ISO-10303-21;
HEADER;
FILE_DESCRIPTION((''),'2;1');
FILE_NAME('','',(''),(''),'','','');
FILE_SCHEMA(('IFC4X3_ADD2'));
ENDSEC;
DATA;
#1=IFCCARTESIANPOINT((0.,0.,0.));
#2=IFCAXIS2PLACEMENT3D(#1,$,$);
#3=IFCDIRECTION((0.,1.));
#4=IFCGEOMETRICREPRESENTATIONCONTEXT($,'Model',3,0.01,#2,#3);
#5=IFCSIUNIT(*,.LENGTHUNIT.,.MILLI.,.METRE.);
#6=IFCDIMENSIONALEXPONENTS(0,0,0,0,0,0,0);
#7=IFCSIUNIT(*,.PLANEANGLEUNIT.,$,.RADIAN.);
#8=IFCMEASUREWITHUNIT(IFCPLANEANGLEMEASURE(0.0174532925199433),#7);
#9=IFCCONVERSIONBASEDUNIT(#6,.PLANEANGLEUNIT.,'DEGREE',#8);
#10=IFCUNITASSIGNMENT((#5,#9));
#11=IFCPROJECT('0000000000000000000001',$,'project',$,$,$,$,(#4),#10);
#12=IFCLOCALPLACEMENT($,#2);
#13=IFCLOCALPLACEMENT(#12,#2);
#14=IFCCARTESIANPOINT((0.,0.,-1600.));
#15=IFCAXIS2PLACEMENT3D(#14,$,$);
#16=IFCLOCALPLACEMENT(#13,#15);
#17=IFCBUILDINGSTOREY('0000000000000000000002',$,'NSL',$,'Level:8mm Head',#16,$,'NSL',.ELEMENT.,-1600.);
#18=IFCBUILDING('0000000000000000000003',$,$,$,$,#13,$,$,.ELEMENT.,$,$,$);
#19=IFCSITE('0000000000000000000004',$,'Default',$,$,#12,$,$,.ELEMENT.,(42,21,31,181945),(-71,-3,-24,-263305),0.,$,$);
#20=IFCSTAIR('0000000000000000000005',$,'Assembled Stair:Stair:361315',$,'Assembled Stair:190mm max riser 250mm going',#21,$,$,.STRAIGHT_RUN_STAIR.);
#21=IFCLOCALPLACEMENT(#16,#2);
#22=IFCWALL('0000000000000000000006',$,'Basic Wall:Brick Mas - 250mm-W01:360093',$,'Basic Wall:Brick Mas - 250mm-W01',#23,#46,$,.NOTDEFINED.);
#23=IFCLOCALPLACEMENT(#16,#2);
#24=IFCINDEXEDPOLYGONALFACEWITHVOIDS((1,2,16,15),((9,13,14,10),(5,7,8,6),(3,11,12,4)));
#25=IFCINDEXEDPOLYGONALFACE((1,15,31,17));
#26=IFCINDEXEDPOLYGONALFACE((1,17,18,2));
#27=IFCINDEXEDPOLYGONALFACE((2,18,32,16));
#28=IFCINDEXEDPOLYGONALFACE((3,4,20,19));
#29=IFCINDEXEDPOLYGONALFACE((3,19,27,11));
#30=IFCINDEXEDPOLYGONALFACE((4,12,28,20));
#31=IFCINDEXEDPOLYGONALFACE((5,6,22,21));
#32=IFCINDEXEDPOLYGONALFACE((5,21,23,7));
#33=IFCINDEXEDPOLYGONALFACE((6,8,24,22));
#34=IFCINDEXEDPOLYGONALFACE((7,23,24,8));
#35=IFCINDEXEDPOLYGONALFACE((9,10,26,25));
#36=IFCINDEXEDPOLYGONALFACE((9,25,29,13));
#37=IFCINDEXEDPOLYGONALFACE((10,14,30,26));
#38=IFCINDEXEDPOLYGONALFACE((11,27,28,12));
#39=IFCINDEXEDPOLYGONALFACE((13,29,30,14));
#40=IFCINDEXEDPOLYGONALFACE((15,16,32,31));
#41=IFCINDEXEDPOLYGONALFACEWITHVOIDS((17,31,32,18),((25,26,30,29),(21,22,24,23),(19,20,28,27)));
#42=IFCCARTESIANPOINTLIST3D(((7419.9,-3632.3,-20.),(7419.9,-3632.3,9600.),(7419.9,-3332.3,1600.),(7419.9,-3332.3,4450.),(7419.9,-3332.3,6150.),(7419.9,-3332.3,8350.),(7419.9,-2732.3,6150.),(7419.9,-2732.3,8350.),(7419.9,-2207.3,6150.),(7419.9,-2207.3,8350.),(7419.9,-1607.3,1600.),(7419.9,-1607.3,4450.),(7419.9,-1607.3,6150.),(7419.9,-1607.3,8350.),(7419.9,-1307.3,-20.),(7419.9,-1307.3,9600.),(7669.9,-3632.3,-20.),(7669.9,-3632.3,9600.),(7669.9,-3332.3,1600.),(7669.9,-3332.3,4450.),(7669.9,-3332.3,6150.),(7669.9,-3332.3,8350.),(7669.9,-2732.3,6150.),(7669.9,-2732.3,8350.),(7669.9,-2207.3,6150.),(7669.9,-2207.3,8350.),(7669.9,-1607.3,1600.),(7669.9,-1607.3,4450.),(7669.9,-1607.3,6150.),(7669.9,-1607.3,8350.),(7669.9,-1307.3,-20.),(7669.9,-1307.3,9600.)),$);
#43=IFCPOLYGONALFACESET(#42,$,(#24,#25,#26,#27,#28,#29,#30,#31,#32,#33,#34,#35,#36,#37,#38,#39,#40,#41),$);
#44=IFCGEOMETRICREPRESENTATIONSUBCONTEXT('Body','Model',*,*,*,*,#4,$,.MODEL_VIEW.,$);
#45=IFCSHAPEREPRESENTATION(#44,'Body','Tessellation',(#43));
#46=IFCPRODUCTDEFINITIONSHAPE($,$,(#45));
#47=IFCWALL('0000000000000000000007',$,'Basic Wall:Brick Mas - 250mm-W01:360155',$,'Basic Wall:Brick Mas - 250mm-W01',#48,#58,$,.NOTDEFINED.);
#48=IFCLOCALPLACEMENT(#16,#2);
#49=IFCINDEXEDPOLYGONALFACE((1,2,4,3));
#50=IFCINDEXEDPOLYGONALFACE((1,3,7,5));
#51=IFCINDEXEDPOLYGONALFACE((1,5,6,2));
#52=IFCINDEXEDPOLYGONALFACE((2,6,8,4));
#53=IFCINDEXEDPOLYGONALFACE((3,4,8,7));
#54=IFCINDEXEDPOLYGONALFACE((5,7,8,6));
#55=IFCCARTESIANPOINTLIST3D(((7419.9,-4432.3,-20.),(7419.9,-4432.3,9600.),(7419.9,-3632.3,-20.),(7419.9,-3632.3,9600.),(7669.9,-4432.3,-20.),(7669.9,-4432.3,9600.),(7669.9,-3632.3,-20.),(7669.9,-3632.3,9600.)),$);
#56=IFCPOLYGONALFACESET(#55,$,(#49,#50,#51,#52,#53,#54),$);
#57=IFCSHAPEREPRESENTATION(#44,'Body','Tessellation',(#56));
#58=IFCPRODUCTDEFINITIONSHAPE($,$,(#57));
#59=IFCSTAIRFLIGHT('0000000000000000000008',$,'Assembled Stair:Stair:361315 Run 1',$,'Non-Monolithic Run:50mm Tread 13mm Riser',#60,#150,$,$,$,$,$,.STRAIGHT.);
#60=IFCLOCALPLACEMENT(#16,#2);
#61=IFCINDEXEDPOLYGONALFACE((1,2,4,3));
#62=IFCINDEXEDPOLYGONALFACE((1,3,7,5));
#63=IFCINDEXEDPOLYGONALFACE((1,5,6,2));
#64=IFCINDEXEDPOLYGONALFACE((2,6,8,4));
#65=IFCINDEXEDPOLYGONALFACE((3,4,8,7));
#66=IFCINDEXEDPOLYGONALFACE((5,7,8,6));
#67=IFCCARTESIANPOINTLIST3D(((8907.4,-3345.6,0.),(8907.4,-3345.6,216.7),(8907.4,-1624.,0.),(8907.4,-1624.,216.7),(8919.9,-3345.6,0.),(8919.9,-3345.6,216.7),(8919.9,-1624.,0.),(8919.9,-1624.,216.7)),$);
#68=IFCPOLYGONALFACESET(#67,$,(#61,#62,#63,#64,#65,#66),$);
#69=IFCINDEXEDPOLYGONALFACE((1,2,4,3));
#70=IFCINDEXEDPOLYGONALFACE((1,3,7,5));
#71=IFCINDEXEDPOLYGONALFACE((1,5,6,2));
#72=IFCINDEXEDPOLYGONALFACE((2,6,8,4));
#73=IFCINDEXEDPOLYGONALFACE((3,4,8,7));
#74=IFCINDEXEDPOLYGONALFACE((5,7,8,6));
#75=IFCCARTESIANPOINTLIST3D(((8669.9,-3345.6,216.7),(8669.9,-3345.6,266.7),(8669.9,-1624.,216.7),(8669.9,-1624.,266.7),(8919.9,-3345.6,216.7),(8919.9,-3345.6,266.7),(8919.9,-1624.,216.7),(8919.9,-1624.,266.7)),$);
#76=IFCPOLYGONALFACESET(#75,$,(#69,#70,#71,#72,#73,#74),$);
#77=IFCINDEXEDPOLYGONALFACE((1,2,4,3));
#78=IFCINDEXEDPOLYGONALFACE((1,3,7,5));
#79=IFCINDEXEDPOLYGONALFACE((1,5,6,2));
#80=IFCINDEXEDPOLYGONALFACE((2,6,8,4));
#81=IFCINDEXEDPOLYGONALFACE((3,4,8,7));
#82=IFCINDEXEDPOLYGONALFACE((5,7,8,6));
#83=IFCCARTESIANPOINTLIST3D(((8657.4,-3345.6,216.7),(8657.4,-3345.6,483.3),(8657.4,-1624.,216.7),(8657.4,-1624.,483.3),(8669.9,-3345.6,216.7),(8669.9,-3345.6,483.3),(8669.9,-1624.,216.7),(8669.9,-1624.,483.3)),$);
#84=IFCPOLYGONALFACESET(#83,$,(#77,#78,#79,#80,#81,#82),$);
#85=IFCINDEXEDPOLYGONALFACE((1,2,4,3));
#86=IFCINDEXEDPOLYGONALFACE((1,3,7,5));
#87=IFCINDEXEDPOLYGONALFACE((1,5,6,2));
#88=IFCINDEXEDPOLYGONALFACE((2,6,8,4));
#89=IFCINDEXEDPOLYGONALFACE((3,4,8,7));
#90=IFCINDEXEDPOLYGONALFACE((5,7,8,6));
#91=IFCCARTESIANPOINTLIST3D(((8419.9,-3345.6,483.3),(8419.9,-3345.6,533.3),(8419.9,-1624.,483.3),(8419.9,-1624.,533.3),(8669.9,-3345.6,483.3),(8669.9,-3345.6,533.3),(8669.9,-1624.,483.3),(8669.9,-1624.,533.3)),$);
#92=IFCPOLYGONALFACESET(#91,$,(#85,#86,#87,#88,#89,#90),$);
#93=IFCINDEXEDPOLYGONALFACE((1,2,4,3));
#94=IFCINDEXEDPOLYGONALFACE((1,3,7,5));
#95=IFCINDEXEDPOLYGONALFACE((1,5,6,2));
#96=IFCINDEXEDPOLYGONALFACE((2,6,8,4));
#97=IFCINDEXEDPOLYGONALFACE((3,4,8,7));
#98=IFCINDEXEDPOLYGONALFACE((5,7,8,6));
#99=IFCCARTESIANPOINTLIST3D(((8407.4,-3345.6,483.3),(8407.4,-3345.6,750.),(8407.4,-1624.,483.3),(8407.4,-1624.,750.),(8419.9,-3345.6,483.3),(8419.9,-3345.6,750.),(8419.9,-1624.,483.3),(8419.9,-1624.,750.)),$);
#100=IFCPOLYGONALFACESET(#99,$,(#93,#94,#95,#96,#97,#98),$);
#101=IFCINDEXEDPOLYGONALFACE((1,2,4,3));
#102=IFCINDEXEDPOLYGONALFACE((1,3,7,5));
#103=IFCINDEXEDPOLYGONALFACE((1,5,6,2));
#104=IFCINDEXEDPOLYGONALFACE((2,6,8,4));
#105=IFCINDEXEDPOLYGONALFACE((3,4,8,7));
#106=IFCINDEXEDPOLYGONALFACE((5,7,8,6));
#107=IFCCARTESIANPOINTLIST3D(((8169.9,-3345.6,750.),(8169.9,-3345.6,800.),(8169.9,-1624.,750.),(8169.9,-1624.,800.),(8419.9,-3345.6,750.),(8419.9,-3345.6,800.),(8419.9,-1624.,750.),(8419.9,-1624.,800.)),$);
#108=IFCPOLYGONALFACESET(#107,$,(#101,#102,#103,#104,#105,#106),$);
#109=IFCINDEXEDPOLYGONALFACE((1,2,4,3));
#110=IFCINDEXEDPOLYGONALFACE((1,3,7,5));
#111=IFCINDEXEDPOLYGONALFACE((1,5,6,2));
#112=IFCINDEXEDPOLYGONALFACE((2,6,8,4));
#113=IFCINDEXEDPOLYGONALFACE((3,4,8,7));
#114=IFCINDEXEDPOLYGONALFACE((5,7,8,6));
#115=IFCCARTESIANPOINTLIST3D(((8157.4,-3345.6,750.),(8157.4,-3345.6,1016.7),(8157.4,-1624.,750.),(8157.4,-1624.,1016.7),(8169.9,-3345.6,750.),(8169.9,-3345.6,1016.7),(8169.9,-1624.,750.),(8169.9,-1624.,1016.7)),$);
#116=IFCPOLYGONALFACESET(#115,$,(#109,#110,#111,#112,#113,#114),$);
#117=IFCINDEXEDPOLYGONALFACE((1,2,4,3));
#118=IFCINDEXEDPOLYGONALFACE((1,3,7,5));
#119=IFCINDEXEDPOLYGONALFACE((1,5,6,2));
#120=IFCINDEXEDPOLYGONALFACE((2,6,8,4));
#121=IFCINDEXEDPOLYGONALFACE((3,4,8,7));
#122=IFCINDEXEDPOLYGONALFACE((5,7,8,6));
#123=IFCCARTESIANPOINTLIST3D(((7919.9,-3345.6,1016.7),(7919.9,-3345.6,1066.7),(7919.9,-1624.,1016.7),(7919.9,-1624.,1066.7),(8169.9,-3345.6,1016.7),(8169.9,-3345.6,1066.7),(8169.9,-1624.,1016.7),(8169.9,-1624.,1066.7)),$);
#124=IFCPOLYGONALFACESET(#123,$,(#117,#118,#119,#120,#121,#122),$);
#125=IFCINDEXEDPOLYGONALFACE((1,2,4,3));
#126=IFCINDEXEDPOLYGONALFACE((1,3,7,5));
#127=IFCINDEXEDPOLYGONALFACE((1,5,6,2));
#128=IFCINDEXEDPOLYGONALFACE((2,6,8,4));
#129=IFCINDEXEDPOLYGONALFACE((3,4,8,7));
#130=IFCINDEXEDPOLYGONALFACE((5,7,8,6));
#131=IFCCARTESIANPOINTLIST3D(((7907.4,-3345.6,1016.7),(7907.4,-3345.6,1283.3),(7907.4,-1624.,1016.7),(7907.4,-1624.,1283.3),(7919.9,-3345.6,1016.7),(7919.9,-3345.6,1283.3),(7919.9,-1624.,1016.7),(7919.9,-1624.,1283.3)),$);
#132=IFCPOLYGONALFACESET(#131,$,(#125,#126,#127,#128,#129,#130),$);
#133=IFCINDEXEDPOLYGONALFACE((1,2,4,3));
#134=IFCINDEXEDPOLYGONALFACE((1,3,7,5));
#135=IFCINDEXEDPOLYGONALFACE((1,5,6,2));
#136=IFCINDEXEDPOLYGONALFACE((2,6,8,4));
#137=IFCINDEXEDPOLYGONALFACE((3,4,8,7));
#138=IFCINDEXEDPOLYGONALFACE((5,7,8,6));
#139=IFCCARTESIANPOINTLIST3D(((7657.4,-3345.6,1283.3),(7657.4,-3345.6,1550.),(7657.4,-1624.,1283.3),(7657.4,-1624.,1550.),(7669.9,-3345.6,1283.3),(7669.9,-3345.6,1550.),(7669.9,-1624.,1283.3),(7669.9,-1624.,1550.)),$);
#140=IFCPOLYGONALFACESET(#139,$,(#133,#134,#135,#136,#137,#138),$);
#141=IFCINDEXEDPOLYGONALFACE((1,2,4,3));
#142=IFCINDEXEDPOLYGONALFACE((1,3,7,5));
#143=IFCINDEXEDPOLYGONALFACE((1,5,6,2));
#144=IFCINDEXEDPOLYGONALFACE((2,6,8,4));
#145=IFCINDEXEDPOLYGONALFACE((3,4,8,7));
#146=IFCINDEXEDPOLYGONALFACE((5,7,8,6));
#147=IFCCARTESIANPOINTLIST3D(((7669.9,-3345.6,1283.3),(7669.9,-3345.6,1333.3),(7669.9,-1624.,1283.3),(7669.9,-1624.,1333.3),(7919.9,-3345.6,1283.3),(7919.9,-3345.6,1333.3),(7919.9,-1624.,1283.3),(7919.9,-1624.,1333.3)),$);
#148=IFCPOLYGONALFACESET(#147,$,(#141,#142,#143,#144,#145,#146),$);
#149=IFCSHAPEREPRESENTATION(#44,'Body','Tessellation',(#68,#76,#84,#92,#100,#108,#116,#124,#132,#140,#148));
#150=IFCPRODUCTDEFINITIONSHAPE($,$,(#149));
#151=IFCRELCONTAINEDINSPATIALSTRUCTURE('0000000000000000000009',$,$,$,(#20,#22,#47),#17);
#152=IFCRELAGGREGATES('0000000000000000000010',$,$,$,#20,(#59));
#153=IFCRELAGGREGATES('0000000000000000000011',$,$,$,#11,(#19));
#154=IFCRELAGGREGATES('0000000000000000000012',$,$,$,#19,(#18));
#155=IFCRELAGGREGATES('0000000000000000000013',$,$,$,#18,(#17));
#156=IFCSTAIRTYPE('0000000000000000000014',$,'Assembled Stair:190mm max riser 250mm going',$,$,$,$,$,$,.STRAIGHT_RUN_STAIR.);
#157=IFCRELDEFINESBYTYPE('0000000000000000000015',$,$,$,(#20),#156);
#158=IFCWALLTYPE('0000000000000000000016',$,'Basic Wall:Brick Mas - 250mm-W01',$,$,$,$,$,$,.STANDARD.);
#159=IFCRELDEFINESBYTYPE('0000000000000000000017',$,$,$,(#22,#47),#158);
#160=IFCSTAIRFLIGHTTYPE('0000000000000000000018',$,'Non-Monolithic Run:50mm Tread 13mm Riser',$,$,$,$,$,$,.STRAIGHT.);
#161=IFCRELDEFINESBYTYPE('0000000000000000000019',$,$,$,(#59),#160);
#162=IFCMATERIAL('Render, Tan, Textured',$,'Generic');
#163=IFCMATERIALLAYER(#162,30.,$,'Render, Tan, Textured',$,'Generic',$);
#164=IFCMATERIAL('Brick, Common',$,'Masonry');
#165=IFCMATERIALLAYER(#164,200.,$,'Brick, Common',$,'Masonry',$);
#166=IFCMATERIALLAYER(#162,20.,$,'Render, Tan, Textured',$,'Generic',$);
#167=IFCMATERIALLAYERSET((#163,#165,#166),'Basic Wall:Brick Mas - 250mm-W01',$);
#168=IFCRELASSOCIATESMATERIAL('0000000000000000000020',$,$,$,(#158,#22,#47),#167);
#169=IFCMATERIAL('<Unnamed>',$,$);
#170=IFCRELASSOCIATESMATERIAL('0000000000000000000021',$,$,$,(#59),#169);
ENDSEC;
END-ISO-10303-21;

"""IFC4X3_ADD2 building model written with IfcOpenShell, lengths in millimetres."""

from ifc_helpers import new_model, entity, si_unit, converted_unit, direction, frame, frame_2d, origin, origin_2d_with_axis, place, context, subcontext, project, spatial, rectangle, extrude, material, layer, layer_set, type_object, element, aggregate, save


model = new_model("IFC4X3_ADD2")

# Units and contexts
model_context = context("Model", 3, precision=0.01, world=origin(), true_north=direction((0.0, 1.0)))
body_context = subcontext(model_context, "Body", "Model", "MODEL_VIEW")
ifc_project = project(units=[si_unit("LENGTHUNIT", "METRE", prefix="MILLI"), converted_unit("PLANEANGLEUNIT", "DEGREE", entity("IfcPlaneAngleMeasure", 0.0174532925199433), si_unit("PLANEANGLEUNIT", "RADIAN"), dimensions=[0, 0, 0, 0, 0, 0, 0])], contexts=[model_context])

# Site, building, storey
site_placement = place(None, origin())
site = spatial("IfcSite", under=ifc_project, at=site_placement, Name="Default", CompositionType="ELEMENT", RefLatitude=(42, 21, 31, 181945), RefLongitude=(-71, -3, -24, -263305), RefElevation=0.0)
building_placement = place(site_placement, origin())
building = spatial("IfcBuilding", under=site, at=building_placement, CompositionType="ELEMENT")
storey_placement = place(building_placement, frame((0.0, 0.0, -1600.0)))
storey = spatial("IfcBuildingStorey", under=building, at=storey_placement, Name="NSL", ObjectType="Level:8mm Head", LongName="NSL", CompositionType="ELEMENT", Elevation=-1600.0)

# Stair
stair_type = type_object("IfcStairType", Name="Assembled Stair:190mm max riser 250mm going", PredefinedType="STRAIGHT_RUN_STAIR")
stair_placement = place(storey_placement, origin())
stair = element("IfcStair", 1, at=stair_placement, inside=storey, type_object=stair_type, Name="Assembled Stair:Stair:361315", ObjectType="Assembled Stair:190mm max riser 250mm going", PredefinedType="STRAIGHT_RUN_STAIR")
ifc_material_1 = material(Name="<Unnamed>")

# Shared definitions
ifc_material_2 = material(Name="Render, Tan, Textured", Category="Generic")
ifc_layer_1 = layer(ifc_material_2, 30.0, Name="Render, Tan, Textured", Category="Generic")
ifc_material_3 = material(Name="Brick, Common", Category="Masonry")
ifc_layer_2 = layer(ifc_material_3, 200.0, Name="Brick, Common", Category="Masonry")
ifc_layer_3 = layer(ifc_material_2, 20.0, Name="Render, Tan, Textured", Category="Generic")
ifc_layer_set = layer_set([ifc_layer_1, ifc_layer_2, ifc_layer_3], Name="Basic Wall:Brick Mas - 250mm-W01")
wall_type = type_object("IfcWallType", Name="Basic Wall:Brick Mas - 250mm-W01", PredefinedType="STANDARD", material=ifc_layer_set)

# Wall, openings
wall_1_placement = place(storey_placement, frame((7544.9, -1307.3, -20.0), z_axis=(0.0, 0.0, 1.0), x_axis=(0.0, -1.0, 0.0)))
wall_1 = element("IfcWall", 2, at=wall_1_placement, inside=storey, type_object=wall_type, material=ifc_layer_set, Name="Basic Wall:Brick Mas - 250mm-W01:360093", ObjectType="Basic Wall:Brick Mas - 250mm-W01", PredefinedType="NOTDEFINED", context=body_context, shape_type="SweptSolid", body=[
    extrude(rectangle(XDim=2325.0, YDim=250.0, at=frame_2d((1162.5, 0.0), x_axis=(-1.0, 0.0))), origin(), (0.0, 0.0, 1.0), 9620.0),
])
opening_1_placement = place(wall_1_placement, origin())
element("IfcOpeningElement", 3, at=opening_1_placement, cuts=wall_1, PredefinedType="OPENING", context=body_context, shape_type="SweptSolid", body=[
    extrude(rectangle(XDim=2850.0, YDim=1725.0, at=origin_2d_with_axis()), frame((1162.5, 125.0, 3045.0), z_axis=(0.0, 1.0, 0.0), x_axis=(0.0, 0.0, 1.0)), (0.0, 0.0, -1.0), 250.0),
])
opening_2_placement = place(wall_1_placement, origin())
element("IfcOpeningElement", 4, at=opening_2_placement, cuts=wall_1, PredefinedType="OPENING", context=body_context, shape_type="SweptSolid", body=[
    extrude(rectangle(XDim=2200.0, YDim=600.0, at=frame_2d((0.0, 0.0), x_axis=(1.0, 0.0))), frame((1725.0, 125.0, 7270.0), z_axis=(0.0, -1.0, 0.0), x_axis=(0.0, 0.0, -1.0)), (0.0, 0.0, 1.0), 250.0),
])
opening_3_placement = place(wall_1_placement, origin())
element("IfcOpeningElement", 5, at=opening_3_placement, cuts=wall_1, PredefinedType="OPENING", context=body_context, shape_type="SweptSolid", body=[
    extrude(rectangle(XDim=2200.0, YDim=600.0, at=origin_2d_with_axis()), frame((600.0, 125.0, 7270.0), z_axis=(0.0, -1.0, 0.0), x_axis=(0.0, 0.0, -1.0)), (0.0, 0.0, 1.0), 250.0),
])

# Wall
wall_2_placement = place(storey_placement, frame((7544.9, -3632.3, -20.0), z_axis=(0.0, 0.0, 1.0), x_axis=(0.0, -1.0, 0.0)))
element("IfcWall", 6, at=wall_2_placement, inside=storey, type_object=wall_type, material=ifc_layer_set, Name="Basic Wall:Brick Mas - 250mm-W01:360155", ObjectType="Basic Wall:Brick Mas - 250mm-W01", PredefinedType="NOTDEFINED", context=body_context, shape_type="SweptSolid", body=[
    extrude(rectangle(XDim=800.0, YDim=250.0, at=frame_2d((400.0, 0.0), x_axis=(-1.0, 0.0))), origin(), (0.0, 0.0, 1.0), 9620.0),
])

# Stair flight
stair_flight_type = type_object("IfcStairFlightType", Name="Non-Monolithic Run:50mm Tread 13mm Riser", PredefinedType="STRAIGHT")
stair_flight_placement = place(stair_placement, frame((7657.4, -3345.6, 0.0)))
stair_flight = element("IfcStairFlight", 7, at=stair_flight_placement, type_object=stair_flight_type, material=ifc_material_1, Name="Assembled Stair:Stair:361315 Run 1", ObjectType="Non-Monolithic Run:50mm Tread 13mm Riser", PredefinedType="STRAIGHT", context=body_context, shape_type="SweptSolid", body=[
    extrude(rectangle(XDim=1721.7, YDim=12.5, at=origin_2d_with_axis()), frame((1256.2, 860.8, 0.0), z_axis=(0.0, 0.0, 1.0), x_axis=(0.0, -1.0, 0.0)), (0.0, 0.0, 1.0), 216.7),
    extrude(rectangle(XDim=250.0, YDim=1721.7, at=frame_2d((0.0, 0.0), x_axis=(1.0, 0.0))), frame((1137.5, 860.8, 216.7)), (0.0, 0.0, 1.0), 50.0),
    extrude(rectangle(XDim=1721.7, YDim=12.5, at=frame_2d((0.0, 0.0), x_axis=(1.0, 0.0))), frame((1006.3, 860.8, 216.7), z_axis=(0.0, 0.0, 1.0), x_axis=(0.0, -1.0, 0.0)), (0.0, 0.0, 1.0), 266.7),
    extrude(rectangle(XDim=250.0, YDim=1721.7, at=frame_2d((0.0, 0.0), x_axis=(1.0, 0.0))), frame((887.5, 860.8, 483.3)), (0.0, 0.0, 1.0), 50.0),
    extrude(rectangle(XDim=1721.7, YDim=12.5, at=origin_2d_with_axis()), frame((756.3, 860.8, 483.3), z_axis=(0.0, 0.0, 1.0), x_axis=(0.0, -1.0, 0.0)), (0.0, 0.0, 1.0), 266.7),
    extrude(rectangle(XDim=250.0, YDim=1721.7, at=origin_2d_with_axis()), frame((637.5, 860.8, 750.0)), (0.0, 0.0, 1.0), 50.0),
    extrude(rectangle(XDim=1721.7, YDim=12.5, at=frame_2d((0.0, 0.0), x_axis=(1.0, 0.0))), frame((506.3, 860.8, 750.0), z_axis=(0.0, 0.0, 1.0), x_axis=(0.0, -1.0, 0.0)), (0.0, 0.0, 1.0), 266.7),
    extrude(rectangle(XDim=250.0, YDim=1721.7, at=origin_2d_with_axis()), frame((387.5, 860.8, 1016.7)), (0.0, 0.0, 1.0), 50.0),
    extrude(rectangle(XDim=1721.7, YDim=12.5, at=origin_2d_with_axis()), frame((256.3, 860.8, 1016.7), z_axis=(0.0, 0.0, 1.0), x_axis=(0.0, -1.0, 0.0)), (0.0, 0.0, 1.0), 266.7),
    extrude(rectangle(XDim=1721.7, YDim=12.5, at=origin_2d_with_axis()), frame((6.3, 860.8, 1283.3), z_axis=(0.0, 0.0, 1.0), x_axis=(0.0, -1.0, 0.0)), (0.0, 0.0, 1.0), 266.7),
    extrude(rectangle(XDim=250.0, YDim=1721.7, at=frame_2d((0.0, 0.0), x_axis=(1.0, 0.0))), frame((137.5, 860.8, 1283.3)), (0.0, 0.0, 1.0), 50.0),
])

aggregate(stair, [stair_flight])

save(model, "model.ifc")
